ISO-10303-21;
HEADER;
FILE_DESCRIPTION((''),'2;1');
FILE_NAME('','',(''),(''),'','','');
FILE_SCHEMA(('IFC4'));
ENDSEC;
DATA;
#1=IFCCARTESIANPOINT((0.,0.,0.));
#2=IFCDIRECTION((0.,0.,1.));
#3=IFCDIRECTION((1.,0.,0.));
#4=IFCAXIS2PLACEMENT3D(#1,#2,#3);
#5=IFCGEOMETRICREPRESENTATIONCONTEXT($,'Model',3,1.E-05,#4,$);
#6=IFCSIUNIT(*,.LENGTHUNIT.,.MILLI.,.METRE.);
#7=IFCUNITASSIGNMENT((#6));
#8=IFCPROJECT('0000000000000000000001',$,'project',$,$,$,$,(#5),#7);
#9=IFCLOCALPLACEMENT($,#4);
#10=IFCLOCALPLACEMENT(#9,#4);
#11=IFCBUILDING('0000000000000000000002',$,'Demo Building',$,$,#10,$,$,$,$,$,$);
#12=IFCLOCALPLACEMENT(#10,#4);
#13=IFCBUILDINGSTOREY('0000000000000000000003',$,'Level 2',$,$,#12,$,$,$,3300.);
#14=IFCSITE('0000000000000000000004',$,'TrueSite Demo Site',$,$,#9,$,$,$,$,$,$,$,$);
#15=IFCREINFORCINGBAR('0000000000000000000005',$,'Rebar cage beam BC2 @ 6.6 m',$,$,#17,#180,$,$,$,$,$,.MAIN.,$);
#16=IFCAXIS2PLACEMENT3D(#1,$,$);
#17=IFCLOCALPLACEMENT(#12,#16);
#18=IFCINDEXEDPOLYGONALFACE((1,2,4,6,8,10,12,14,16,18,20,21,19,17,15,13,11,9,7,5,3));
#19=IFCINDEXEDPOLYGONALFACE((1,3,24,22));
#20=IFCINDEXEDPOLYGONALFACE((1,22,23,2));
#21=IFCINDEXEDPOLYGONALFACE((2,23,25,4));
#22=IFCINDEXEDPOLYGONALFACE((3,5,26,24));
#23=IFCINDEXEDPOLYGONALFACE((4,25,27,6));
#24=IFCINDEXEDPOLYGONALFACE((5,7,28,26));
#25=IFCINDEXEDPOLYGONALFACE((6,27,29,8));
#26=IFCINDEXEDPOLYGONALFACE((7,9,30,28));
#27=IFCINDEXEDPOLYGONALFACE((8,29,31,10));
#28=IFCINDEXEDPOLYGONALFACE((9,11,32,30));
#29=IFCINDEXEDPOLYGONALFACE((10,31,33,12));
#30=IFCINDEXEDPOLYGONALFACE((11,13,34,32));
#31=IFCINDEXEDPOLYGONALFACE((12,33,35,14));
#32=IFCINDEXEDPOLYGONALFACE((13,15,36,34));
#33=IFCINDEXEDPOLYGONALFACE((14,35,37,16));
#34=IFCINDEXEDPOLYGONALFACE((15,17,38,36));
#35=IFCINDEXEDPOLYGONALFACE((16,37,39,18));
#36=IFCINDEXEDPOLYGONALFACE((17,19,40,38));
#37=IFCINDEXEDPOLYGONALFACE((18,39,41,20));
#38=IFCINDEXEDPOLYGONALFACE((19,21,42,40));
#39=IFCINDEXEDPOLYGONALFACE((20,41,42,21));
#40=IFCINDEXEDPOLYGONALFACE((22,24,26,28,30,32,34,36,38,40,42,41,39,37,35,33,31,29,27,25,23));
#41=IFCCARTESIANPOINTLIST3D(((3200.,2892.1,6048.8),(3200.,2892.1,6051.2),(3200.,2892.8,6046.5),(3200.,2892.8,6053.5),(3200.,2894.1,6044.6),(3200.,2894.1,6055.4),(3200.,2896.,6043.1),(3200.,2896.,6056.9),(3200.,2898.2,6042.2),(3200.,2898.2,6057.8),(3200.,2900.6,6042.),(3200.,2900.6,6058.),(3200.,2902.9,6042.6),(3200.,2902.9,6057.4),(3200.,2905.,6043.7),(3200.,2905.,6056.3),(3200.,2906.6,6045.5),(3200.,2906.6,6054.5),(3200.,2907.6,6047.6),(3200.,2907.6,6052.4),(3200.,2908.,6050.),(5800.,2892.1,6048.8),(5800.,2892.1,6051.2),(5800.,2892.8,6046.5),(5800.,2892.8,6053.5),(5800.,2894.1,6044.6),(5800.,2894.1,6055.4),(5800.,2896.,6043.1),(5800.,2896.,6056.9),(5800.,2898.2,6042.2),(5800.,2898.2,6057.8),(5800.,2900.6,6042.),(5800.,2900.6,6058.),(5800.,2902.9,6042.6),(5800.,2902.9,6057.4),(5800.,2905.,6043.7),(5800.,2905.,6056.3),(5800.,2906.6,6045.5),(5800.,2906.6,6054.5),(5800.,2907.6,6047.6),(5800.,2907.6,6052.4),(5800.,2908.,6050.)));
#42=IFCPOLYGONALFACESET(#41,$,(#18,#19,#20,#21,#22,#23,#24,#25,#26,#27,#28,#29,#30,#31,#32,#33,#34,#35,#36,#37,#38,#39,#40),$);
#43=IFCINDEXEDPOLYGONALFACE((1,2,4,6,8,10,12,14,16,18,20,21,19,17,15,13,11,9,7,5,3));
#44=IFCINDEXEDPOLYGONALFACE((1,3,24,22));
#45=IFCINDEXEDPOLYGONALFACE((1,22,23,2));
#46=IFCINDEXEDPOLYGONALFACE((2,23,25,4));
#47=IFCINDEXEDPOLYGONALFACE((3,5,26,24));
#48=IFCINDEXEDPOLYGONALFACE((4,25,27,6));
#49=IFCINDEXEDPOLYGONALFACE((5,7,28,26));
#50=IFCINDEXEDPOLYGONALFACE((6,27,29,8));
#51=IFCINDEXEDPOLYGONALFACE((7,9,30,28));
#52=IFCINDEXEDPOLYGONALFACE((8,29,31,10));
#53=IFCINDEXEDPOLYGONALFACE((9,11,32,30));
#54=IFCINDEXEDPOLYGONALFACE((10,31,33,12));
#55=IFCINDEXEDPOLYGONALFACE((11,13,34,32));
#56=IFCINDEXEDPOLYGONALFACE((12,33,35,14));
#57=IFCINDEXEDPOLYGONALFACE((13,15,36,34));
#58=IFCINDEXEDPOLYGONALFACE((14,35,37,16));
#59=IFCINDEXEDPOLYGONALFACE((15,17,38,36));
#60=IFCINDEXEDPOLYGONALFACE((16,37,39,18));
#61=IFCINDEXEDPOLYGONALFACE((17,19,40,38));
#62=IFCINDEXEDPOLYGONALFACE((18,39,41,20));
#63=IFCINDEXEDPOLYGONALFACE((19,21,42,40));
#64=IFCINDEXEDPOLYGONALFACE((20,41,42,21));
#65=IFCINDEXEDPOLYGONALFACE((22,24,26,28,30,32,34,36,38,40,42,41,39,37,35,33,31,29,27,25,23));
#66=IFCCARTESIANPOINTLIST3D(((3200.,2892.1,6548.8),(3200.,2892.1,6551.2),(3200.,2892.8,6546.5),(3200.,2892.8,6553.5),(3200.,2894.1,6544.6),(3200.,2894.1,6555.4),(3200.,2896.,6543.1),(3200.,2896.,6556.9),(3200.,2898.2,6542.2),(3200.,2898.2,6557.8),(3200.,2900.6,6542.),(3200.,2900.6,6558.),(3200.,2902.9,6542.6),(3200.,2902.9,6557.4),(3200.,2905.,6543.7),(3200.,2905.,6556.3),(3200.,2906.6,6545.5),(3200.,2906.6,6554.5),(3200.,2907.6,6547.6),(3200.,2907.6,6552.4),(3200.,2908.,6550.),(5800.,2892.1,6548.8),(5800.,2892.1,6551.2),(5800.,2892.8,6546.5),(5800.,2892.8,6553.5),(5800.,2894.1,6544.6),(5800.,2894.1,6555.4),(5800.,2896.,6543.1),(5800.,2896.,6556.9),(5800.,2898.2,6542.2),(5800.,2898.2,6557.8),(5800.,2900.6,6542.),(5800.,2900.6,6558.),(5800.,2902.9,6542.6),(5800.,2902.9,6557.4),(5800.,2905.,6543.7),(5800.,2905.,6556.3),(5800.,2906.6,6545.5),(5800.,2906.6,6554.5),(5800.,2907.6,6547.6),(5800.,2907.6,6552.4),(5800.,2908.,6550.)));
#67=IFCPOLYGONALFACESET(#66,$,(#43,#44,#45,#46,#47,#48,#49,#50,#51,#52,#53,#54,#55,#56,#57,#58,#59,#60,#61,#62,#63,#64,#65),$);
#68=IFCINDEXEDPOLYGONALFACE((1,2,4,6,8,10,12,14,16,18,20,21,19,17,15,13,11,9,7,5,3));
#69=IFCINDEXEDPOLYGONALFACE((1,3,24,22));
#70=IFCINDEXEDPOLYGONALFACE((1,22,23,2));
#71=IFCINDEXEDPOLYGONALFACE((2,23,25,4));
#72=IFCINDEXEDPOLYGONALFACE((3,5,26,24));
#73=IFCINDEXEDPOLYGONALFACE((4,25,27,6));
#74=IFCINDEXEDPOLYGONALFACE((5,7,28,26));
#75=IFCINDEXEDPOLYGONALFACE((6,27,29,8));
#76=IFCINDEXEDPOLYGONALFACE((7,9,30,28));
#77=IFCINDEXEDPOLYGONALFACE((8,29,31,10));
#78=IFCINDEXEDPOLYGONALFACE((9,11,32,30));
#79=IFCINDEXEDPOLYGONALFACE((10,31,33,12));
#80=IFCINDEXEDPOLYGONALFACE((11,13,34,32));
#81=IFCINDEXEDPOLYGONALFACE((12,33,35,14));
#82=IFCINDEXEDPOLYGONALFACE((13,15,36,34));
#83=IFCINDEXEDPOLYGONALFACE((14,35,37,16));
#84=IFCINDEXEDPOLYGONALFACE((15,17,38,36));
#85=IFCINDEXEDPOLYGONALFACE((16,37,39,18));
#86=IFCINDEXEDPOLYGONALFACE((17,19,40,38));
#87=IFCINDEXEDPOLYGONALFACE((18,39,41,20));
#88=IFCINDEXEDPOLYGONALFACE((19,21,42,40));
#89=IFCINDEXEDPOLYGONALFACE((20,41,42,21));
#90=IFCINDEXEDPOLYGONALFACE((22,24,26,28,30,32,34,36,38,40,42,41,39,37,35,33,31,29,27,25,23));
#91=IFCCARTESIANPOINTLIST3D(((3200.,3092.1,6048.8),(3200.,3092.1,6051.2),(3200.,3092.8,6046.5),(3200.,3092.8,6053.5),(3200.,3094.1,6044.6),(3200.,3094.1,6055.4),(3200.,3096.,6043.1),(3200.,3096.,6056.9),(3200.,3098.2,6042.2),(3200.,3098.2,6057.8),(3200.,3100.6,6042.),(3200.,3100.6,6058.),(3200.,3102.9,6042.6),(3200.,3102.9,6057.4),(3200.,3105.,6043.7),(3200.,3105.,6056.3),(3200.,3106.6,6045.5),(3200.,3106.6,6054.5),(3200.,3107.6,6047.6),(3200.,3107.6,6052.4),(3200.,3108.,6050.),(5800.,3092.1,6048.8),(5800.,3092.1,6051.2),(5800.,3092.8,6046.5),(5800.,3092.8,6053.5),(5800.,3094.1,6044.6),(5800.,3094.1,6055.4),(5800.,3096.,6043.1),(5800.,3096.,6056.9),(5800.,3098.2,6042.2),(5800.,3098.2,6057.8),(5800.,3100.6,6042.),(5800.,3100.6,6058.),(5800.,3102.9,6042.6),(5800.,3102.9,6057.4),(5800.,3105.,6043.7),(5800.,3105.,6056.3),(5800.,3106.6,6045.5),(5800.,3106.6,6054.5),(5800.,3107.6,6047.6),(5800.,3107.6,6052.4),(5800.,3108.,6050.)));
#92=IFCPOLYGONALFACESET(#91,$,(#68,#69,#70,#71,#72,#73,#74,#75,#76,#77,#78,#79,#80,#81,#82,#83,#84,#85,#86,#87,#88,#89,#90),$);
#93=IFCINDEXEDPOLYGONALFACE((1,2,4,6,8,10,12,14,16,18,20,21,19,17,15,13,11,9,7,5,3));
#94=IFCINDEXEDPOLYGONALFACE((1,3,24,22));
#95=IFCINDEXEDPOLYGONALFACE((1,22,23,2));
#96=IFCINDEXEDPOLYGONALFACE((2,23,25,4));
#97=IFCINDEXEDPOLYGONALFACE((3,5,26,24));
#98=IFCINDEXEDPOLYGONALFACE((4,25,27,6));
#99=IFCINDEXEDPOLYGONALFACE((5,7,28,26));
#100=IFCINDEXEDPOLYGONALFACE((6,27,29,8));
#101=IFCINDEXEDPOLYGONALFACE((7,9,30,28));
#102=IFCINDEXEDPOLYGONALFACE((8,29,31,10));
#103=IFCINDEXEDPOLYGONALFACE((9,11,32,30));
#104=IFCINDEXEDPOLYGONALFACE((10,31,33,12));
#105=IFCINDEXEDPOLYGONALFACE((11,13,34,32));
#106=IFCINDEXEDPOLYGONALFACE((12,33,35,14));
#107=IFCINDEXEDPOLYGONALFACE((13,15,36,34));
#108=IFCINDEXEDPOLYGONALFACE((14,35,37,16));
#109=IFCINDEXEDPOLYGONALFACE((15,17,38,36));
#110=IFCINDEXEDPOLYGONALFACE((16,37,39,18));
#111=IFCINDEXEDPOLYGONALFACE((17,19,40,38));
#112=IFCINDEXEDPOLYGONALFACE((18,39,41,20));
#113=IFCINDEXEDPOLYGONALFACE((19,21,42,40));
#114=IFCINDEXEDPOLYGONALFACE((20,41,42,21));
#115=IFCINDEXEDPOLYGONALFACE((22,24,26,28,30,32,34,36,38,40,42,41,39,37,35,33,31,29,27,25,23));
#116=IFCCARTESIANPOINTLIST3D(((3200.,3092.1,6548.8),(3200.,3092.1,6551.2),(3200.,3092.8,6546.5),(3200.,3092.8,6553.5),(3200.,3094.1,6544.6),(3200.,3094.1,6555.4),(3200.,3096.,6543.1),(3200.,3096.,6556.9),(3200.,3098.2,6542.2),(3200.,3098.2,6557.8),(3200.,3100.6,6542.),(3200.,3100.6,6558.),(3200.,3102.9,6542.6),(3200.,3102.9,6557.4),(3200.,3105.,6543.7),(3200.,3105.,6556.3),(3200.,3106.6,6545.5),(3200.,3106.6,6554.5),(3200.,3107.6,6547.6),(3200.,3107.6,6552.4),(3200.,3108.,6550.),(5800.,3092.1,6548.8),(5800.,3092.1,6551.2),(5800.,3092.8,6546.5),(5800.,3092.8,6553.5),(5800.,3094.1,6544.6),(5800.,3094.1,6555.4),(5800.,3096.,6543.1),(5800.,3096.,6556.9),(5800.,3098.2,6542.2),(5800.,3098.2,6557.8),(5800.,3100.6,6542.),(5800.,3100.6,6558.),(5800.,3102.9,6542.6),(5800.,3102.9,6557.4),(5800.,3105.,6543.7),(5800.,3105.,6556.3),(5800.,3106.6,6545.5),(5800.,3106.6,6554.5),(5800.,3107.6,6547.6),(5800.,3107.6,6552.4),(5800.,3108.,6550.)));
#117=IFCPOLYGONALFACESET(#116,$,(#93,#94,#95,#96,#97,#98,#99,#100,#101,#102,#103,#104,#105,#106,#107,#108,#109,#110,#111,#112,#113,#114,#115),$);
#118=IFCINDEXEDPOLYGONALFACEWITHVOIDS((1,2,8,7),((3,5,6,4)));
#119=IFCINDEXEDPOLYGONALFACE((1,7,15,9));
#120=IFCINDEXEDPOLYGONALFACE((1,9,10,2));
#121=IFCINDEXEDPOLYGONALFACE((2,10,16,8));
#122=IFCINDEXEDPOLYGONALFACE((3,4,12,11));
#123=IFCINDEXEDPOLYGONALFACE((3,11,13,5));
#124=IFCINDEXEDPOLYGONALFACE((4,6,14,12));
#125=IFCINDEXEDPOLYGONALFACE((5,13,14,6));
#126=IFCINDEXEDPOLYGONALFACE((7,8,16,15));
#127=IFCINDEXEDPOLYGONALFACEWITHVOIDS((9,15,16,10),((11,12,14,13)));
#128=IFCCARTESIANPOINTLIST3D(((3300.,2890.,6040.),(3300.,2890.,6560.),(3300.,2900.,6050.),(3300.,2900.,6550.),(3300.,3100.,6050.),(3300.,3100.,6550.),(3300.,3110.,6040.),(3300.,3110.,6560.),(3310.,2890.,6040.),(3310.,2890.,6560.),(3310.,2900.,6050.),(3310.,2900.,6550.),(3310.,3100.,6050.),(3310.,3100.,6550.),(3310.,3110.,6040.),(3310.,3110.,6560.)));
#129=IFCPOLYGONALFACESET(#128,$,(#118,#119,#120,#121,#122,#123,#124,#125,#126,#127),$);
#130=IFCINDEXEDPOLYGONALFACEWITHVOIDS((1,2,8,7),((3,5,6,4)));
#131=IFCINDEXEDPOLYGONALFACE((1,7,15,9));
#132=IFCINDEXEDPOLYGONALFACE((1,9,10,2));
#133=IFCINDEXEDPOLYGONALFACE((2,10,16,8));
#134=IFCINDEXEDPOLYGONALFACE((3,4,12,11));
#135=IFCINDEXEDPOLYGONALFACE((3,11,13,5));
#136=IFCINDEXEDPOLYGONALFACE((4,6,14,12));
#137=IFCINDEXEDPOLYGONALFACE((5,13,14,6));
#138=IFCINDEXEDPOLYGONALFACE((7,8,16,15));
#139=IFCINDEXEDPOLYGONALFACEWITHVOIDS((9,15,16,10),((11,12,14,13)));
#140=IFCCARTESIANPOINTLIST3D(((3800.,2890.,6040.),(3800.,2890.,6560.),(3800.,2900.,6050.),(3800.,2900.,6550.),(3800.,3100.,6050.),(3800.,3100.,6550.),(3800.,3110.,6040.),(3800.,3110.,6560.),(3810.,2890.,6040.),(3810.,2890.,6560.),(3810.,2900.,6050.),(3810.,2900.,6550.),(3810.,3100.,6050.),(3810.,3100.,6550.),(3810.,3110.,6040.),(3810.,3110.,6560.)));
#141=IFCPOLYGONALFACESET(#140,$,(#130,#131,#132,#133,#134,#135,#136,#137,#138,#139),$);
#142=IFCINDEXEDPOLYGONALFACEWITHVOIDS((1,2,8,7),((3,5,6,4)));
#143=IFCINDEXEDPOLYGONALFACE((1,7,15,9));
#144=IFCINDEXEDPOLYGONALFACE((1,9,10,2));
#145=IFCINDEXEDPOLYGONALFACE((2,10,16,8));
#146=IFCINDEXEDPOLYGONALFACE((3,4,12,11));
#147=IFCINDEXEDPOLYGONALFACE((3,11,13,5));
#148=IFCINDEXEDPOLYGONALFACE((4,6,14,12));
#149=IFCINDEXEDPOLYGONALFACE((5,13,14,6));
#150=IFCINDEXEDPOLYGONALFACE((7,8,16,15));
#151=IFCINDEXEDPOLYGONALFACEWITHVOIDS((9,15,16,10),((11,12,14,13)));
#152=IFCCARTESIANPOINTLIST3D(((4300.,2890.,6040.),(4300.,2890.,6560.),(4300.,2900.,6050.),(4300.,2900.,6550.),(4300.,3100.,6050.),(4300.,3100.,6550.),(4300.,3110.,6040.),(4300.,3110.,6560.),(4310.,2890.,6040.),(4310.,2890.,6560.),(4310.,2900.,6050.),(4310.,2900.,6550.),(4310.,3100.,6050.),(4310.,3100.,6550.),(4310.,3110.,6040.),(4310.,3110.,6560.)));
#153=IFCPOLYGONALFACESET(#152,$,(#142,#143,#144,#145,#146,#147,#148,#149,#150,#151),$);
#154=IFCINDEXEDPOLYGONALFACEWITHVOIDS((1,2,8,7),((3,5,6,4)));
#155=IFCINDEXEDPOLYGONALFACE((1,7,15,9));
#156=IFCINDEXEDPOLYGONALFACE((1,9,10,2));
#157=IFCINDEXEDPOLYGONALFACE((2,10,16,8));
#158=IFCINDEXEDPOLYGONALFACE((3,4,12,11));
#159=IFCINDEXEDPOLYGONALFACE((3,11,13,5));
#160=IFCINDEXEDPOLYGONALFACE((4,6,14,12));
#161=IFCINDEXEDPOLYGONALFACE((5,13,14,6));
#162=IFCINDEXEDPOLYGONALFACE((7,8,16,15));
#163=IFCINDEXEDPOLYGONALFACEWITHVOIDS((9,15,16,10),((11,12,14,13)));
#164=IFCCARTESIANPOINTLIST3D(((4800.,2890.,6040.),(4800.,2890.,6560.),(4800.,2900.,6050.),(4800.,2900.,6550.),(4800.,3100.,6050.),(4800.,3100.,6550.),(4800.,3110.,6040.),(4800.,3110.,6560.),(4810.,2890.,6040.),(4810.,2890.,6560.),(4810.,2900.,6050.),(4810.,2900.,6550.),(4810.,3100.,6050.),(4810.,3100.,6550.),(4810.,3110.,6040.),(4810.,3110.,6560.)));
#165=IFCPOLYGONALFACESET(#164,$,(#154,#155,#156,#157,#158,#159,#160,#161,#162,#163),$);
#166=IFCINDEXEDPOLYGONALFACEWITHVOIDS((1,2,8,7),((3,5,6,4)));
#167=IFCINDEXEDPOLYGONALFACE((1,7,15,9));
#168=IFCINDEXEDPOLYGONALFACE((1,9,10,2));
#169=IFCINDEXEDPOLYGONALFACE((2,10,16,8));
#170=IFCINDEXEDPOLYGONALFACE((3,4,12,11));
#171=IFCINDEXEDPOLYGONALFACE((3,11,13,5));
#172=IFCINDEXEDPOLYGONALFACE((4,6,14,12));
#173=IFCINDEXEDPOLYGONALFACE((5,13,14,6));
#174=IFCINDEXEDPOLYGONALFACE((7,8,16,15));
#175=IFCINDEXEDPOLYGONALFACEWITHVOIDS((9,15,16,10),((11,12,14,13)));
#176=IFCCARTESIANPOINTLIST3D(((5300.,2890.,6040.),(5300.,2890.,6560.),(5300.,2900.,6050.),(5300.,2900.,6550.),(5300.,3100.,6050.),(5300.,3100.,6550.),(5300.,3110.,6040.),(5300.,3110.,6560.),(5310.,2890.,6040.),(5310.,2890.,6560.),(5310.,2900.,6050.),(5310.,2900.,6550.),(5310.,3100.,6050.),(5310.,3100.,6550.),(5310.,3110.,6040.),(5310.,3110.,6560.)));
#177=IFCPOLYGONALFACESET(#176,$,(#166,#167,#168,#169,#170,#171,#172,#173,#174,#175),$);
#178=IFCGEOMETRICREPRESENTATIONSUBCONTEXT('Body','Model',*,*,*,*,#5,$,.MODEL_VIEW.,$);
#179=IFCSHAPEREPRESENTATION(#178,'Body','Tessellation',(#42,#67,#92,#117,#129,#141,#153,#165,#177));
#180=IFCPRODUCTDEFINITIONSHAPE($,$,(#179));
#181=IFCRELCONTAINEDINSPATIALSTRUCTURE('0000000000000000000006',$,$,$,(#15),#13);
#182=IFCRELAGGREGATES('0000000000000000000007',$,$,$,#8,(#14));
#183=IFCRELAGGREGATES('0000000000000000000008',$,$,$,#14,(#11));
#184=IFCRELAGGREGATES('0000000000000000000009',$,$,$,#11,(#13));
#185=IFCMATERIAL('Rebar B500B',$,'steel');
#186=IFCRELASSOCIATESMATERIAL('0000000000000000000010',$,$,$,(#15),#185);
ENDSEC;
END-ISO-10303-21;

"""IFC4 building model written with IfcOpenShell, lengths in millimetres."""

from ifc_helpers import new_model, si_unit, frame, origin_with_axes, place, context, subcontext, project, spatial, hollow_rectangle, circle, extrude, material, element, save


model = new_model("IFC4")

# Units and contexts
model_context = context("Model", 3, precision=1e-05, world=origin_with_axes())
body_context = subcontext(model_context, "Body", "Model", "MODEL_VIEW")
ifc_project = project(units=[si_unit("LENGTHUNIT", "METRE", prefix="MILLI")], contexts=[model_context])

# Site, building, storey
site_placement = place(None, origin_with_axes())
site = spatial("IfcSite", under=ifc_project, at=site_placement, Name="TrueSite Demo Site")
building_placement = place(site_placement, origin_with_axes())
building = spatial("IfcBuilding", under=site, at=building_placement, Name="Demo Building")
storey_placement = place(building_placement, origin_with_axes())
storey = spatial("IfcBuildingStorey", under=building, at=storey_placement, Name="Level 2", Elevation=3300.0)

# Reinforcing bar
ifc_material_1 = material(Name="Rebar B500B", Category="steel")
for number, where, z_axis, x_axis, name in (
    (1, (3200.0, 3000.0, 6300.0), (1.0, 0.0, 0.0), (0.0, 1.0, 0.0), "Rebar cage beam BC2 @ 6.6 m"),
):
    element("IfcReinforcingBar", number, at=place(storey_placement, frame(where, z_axis=z_axis, x_axis=x_axis)), inside=storey, material=ifc_material_1, Name=name, PredefinedType="MAIN", context=body_context, shape_type="SweptSolid", body=[
        extrude(circle(Radius=8.0), frame((-100.0, -250.0, 0.0)), (0.0, 0.0, 1.0), 2600.0),
        extrude(circle(Radius=8.0), frame((-100.0, 250.0, 0.0)), (0.0, 0.0, 1.0), 2600.0),
        extrude(circle(Radius=8.0), frame((100.0, -250.0, 0.0)), (0.0, 0.0, 1.0), 2600.0),
        extrude(circle(Radius=8.0), frame((100.0, 250.0, 0.0)), (0.0, 0.0, 1.0), 2600.0),
        extrude(hollow_rectangle(XDim=220.0, YDim=520.0, WallThickness=10.0), frame((0.0, 0.0, 100.0)), (0.0, 0.0, 1.0), 10.0),
        extrude(hollow_rectangle(XDim=220.0, YDim=520.0, WallThickness=10.0), frame((0.0, 0.0, 600.0)), (0.0, 0.0, 1.0), 10.0),
        extrude(hollow_rectangle(XDim=220.0, YDim=520.0, WallThickness=10.0), frame((0.0, 0.0, 1100.0)), (0.0, 0.0, 1.0), 10.0),
        extrude(hollow_rectangle(XDim=220.0, YDim=520.0, WallThickness=10.0), frame((0.0, 0.0, 1600.0)), (0.0, 0.0, 1.0), 10.0),
        extrude(hollow_rectangle(XDim=220.0, YDim=520.0, WallThickness=10.0), frame((0.0, 0.0, 2100.0)), (0.0, 0.0, 1.0), 10.0),
    ])

save(model, "model.ifc")
